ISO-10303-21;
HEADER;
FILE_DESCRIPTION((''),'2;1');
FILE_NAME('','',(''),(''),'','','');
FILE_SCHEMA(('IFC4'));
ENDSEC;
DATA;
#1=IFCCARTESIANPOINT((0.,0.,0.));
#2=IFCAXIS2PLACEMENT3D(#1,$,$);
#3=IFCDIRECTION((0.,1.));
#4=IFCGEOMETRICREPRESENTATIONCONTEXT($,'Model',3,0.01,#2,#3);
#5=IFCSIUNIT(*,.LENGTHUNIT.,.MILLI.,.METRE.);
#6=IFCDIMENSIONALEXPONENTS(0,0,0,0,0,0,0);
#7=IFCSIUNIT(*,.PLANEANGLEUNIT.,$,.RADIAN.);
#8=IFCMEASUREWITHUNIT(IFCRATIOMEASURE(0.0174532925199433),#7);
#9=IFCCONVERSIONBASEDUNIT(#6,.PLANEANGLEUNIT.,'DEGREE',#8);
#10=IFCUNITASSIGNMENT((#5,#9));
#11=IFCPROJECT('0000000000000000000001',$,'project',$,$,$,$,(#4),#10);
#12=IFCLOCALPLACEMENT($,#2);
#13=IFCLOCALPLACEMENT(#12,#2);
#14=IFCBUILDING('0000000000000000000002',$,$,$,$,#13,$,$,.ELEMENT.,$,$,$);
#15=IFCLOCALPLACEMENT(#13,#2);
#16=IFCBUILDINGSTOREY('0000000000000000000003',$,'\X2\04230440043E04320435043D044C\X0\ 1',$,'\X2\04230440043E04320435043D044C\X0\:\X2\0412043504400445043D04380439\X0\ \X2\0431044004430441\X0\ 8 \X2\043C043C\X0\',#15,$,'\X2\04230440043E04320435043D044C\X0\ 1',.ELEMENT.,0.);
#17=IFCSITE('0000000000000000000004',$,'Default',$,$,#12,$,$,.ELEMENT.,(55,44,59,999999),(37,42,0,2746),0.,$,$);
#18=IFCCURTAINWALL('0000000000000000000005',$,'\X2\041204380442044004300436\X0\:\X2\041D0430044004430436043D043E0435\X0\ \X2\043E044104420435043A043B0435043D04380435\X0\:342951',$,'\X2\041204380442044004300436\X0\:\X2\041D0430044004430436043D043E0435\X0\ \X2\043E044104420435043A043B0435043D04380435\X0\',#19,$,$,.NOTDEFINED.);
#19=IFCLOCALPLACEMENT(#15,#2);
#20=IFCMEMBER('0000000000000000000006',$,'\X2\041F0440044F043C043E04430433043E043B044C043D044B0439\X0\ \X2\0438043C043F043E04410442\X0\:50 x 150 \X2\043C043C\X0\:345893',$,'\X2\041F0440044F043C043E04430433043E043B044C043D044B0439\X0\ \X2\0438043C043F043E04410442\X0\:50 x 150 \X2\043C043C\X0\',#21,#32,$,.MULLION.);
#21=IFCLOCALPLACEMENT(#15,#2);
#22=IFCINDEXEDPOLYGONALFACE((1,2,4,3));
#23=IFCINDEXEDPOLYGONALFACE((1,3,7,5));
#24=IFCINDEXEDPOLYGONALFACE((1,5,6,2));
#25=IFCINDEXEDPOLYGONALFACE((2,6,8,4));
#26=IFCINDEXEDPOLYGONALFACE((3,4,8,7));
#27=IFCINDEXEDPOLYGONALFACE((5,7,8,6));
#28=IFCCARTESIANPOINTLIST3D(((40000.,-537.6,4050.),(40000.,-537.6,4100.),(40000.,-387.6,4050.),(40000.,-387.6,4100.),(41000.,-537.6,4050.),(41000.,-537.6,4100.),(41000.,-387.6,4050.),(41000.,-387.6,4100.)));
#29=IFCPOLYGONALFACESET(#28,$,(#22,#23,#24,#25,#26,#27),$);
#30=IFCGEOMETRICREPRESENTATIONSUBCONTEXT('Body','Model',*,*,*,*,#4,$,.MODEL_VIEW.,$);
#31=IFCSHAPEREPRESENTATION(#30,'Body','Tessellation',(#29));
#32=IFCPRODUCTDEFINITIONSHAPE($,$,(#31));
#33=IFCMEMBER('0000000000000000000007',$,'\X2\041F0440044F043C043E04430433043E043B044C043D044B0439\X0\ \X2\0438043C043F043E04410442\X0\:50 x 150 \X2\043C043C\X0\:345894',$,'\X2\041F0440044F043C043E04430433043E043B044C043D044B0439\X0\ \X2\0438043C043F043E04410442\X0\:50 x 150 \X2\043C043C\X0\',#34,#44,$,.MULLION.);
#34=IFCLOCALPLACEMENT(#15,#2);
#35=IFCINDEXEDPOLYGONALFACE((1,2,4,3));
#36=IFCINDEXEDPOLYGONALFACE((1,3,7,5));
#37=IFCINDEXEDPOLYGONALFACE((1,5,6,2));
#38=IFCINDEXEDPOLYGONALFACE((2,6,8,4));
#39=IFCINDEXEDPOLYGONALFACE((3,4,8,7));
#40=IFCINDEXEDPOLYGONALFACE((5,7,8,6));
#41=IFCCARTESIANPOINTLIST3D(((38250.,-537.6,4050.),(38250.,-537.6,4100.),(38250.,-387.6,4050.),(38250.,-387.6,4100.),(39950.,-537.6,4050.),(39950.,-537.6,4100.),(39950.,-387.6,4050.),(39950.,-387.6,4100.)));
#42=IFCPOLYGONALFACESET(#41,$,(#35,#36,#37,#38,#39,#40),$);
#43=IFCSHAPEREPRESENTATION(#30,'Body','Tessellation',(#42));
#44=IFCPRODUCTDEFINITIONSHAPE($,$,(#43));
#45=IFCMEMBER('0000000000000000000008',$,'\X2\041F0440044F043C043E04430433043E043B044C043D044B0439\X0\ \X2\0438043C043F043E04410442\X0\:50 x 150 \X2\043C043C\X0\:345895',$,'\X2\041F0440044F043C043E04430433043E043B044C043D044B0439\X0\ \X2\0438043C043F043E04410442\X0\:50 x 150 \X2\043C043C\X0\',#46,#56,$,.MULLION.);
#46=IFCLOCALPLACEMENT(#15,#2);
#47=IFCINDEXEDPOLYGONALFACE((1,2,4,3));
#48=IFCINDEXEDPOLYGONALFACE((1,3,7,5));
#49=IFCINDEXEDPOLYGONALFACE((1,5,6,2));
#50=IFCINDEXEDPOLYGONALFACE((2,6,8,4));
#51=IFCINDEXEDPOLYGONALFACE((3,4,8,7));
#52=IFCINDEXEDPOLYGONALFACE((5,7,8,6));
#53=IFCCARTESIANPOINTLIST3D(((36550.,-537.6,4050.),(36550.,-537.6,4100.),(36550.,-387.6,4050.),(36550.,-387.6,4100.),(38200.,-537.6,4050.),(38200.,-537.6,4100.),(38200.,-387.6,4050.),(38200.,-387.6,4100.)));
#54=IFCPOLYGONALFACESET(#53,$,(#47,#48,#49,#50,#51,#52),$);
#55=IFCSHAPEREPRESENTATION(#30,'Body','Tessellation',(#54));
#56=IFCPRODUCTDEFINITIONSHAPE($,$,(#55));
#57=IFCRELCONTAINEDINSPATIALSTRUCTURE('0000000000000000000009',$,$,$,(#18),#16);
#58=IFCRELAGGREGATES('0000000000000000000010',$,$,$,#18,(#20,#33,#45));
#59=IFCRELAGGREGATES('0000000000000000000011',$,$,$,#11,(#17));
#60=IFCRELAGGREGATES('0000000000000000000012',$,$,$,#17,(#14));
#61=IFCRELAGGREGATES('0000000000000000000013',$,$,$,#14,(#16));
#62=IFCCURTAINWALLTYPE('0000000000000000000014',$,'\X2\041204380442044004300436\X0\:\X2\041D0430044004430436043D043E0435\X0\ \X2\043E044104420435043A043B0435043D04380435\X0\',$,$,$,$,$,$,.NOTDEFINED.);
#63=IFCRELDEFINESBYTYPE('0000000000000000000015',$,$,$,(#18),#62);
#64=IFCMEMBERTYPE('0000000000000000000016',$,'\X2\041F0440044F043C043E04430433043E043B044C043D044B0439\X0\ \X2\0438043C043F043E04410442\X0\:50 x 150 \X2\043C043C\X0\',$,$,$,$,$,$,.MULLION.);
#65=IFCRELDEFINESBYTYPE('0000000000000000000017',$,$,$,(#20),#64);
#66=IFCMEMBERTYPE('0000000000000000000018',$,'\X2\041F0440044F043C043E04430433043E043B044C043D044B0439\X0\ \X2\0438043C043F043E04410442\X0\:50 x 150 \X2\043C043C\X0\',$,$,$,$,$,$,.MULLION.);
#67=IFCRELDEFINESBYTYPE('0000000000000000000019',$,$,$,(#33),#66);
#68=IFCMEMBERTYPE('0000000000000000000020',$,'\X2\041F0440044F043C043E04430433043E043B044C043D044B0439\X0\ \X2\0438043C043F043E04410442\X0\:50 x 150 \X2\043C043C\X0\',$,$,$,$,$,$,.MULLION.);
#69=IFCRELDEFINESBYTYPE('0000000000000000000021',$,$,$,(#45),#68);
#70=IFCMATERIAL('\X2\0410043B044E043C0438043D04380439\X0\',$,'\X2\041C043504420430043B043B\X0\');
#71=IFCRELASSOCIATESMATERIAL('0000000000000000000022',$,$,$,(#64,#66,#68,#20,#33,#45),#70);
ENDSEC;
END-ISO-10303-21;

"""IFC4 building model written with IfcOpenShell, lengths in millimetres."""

from ifc_helpers import new_model, entity, si_unit, converted_unit, direction, frame, origin, origin_2d_with_axis, place, context, subcontext, project, spatial, rectangle, extrude, source, transform, mapped, material, material_profile, profile_set, profile_usage, type_object, type_shapes, element, aggregate, save


model = new_model("IFC4")

# Units and contexts
model_context = context("Model", 3, precision=0.01, world=origin(), true_north=direction((0.0, 1.0)))
body_context = subcontext(model_context, "Body", "Model", "MODEL_VIEW")
ifc_project = project(units=[si_unit("LENGTHUNIT", "METRE", prefix="MILLI"), converted_unit("PLANEANGLEUNIT", "DEGREE", entity("IfcRatioMeasure", 0.0174532925199433), si_unit("PLANEANGLEUNIT", "RADIAN"), dimensions=[0, 0, 0, 0, 0, 0, 0])], contexts=[model_context])

# Site, building, storey
site_placement = place(None, origin())
site = spatial("IfcSite", under=ifc_project, at=site_placement, Name="Default", CompositionType="ELEMENT", RefLatitude=(55, 44, 59, 999999), RefLongitude=(37, 42, 0, 2746), RefElevation=0.0)
building_placement = place(site_placement, origin())
building = spatial("IfcBuilding", under=site, at=building_placement, CompositionType="ELEMENT")
storey_placement = place(building_placement, origin())
storey = spatial("IfcBuildingStorey", under=building, at=storey_placement, Name="Уровень 1", ObjectType="Уровень:Верхний брус 8 мм", LongName="Уровень 1", CompositionType="ELEMENT", Elevation=0.0)

# Curtain wall, members
curtain_wall_type = type_object("IfcCurtainWallType", Name="Витраж:Наружное остекление", PredefinedType="NOTDEFINED")
curtain_wall_placement = place(storey_placement, origin())
curtain_wall = element("IfcCurtainWall", 1, at=curtain_wall_placement, inside=storey, type_object=curtain_wall_type, Name="Витраж:Наружное остекление:342951", ObjectType="Витраж:Наружное остекление", PredefinedType="NOTDEFINED")
ifc_material_1 = material(Name="Алюминий", Category="Металл")
ifc_material_profile = material_profile(ifc_material_1, rectangle(XDim=150.0, YDim=50.0, at=origin_2d_with_axis()), Name="50 x 150 мм")
ifc_profile_set = profile_set([ifc_material_profile], Name="50 x 150 мм")
ifc_profile_usage_1 = profile_usage(ifc_profile_set)
member_type_1 = type_object("IfcMemberType", Name="Прямоугольный импост:50 x 150 мм", PredefinedType="MULLION", material=ifc_profile_set)
shared_shape_1 = source(origin(), body_context, "Body", "SweptSolid", [
    extrude(rectangle(XDim=150.0, YDim=50.0, at=origin_2d_with_axis()), frame((-25.0, 0.0, -1000.0), z_axis=(0.0, 0.0, 1.0), x_axis=(0.0, -1.0, 0.0)), (0.0, 0.0, 1.0), 1000.0),
])
type_shapes(member_type_1, [shared_shape_1])
member_1_placement = place(storey_placement, frame((41000.0, -462.6, 4100.0), z_axis=(1.0, 0.0, 0.0), x_axis=(0.0, 0.0, 1.0)))
member_1 = element("IfcMember", 2, at=member_1_placement, type_object=member_type_1, material=ifc_profile_usage_1, Name="Прямоугольный импост:50 x 150 мм:345893", ObjectType="Прямоугольный импост:50 x 150 мм", PredefinedType="MULLION", context=body_context, shape_type="MappedRepresentation", body=[
    mapped(shared_shape_1, transform((0.0, 0.0, 0.0), scale=1.0)),
])
ifc_profile_usage_2 = profile_usage(ifc_profile_set)
member_type_2 = type_object("IfcMemberType", Name="Прямоугольный импост:50 x 150 мм", PredefinedType="MULLION", material=ifc_profile_set)
shared_shape_2 = source(origin(), body_context, "Body", "SweptSolid", [
    extrude(rectangle(XDim=150.0, YDim=50.0, at=origin_2d_with_axis()), frame((-25.0, 0.0, -1700.0), z_axis=(0.0, 0.0, 1.0), x_axis=(0.0, -1.0, 0.0)), (0.0, 0.0, 1.0), 1700.0),
])
type_shapes(member_type_2, [shared_shape_2])
member_2_placement = place(storey_placement, frame((39950.0, -462.6, 4100.0), z_axis=(1.0, 0.0, 0.0), x_axis=(0.0, 0.0, 1.0)))
member_2 = element("IfcMember", 3, at=member_2_placement, type_object=member_type_2, material=ifc_profile_usage_2, Name="Прямоугольный импост:50 x 150 мм:345894", ObjectType="Прямоугольный импост:50 x 150 мм", PredefinedType="MULLION", context=body_context, shape_type="MappedRepresentation", body=[
    mapped(shared_shape_2, transform((0.0, 0.0, 0.0), scale=1.0)),
])
ifc_profile_usage_3 = profile_usage(ifc_profile_set)
member_type_3 = type_object("IfcMemberType", Name="Прямоугольный импост:50 x 150 мм", PredefinedType="MULLION", material=ifc_profile_set)
shared_shape_3 = source(origin(), body_context, "Body", "SweptSolid", [
    extrude(rectangle(XDim=150.0, YDim=50.0, at=origin_2d_with_axis()), frame((-25.0, 0.0, -1650.0), z_axis=(0.0, 0.0, 1.0), x_axis=(0.0, -1.0, 0.0)), (0.0, 0.0, 1.0), 1650.0),
])
type_shapes(member_type_3, [shared_shape_3])
member_3_placement = place(storey_placement, frame((38200.0, -462.6, 4100.0), z_axis=(1.0, 0.0, 0.0), x_axis=(0.0, 0.0, 1.0)))
member_3 = element("IfcMember", 4, at=member_3_placement, type_object=member_type_3, material=ifc_profile_usage_3, Name="Прямоугольный импост:50 x 150 мм:345895", ObjectType="Прямоугольный импост:50 x 150 мм", PredefinedType="MULLION", context=body_context, shape_type="MappedRepresentation", body=[
    mapped(shared_shape_3, transform((0.0, 0.0, 0.0), scale=1.0)),
])
aggregate(curtain_wall, [member_1, member_2, member_3])

save(model, "model.ifc")
